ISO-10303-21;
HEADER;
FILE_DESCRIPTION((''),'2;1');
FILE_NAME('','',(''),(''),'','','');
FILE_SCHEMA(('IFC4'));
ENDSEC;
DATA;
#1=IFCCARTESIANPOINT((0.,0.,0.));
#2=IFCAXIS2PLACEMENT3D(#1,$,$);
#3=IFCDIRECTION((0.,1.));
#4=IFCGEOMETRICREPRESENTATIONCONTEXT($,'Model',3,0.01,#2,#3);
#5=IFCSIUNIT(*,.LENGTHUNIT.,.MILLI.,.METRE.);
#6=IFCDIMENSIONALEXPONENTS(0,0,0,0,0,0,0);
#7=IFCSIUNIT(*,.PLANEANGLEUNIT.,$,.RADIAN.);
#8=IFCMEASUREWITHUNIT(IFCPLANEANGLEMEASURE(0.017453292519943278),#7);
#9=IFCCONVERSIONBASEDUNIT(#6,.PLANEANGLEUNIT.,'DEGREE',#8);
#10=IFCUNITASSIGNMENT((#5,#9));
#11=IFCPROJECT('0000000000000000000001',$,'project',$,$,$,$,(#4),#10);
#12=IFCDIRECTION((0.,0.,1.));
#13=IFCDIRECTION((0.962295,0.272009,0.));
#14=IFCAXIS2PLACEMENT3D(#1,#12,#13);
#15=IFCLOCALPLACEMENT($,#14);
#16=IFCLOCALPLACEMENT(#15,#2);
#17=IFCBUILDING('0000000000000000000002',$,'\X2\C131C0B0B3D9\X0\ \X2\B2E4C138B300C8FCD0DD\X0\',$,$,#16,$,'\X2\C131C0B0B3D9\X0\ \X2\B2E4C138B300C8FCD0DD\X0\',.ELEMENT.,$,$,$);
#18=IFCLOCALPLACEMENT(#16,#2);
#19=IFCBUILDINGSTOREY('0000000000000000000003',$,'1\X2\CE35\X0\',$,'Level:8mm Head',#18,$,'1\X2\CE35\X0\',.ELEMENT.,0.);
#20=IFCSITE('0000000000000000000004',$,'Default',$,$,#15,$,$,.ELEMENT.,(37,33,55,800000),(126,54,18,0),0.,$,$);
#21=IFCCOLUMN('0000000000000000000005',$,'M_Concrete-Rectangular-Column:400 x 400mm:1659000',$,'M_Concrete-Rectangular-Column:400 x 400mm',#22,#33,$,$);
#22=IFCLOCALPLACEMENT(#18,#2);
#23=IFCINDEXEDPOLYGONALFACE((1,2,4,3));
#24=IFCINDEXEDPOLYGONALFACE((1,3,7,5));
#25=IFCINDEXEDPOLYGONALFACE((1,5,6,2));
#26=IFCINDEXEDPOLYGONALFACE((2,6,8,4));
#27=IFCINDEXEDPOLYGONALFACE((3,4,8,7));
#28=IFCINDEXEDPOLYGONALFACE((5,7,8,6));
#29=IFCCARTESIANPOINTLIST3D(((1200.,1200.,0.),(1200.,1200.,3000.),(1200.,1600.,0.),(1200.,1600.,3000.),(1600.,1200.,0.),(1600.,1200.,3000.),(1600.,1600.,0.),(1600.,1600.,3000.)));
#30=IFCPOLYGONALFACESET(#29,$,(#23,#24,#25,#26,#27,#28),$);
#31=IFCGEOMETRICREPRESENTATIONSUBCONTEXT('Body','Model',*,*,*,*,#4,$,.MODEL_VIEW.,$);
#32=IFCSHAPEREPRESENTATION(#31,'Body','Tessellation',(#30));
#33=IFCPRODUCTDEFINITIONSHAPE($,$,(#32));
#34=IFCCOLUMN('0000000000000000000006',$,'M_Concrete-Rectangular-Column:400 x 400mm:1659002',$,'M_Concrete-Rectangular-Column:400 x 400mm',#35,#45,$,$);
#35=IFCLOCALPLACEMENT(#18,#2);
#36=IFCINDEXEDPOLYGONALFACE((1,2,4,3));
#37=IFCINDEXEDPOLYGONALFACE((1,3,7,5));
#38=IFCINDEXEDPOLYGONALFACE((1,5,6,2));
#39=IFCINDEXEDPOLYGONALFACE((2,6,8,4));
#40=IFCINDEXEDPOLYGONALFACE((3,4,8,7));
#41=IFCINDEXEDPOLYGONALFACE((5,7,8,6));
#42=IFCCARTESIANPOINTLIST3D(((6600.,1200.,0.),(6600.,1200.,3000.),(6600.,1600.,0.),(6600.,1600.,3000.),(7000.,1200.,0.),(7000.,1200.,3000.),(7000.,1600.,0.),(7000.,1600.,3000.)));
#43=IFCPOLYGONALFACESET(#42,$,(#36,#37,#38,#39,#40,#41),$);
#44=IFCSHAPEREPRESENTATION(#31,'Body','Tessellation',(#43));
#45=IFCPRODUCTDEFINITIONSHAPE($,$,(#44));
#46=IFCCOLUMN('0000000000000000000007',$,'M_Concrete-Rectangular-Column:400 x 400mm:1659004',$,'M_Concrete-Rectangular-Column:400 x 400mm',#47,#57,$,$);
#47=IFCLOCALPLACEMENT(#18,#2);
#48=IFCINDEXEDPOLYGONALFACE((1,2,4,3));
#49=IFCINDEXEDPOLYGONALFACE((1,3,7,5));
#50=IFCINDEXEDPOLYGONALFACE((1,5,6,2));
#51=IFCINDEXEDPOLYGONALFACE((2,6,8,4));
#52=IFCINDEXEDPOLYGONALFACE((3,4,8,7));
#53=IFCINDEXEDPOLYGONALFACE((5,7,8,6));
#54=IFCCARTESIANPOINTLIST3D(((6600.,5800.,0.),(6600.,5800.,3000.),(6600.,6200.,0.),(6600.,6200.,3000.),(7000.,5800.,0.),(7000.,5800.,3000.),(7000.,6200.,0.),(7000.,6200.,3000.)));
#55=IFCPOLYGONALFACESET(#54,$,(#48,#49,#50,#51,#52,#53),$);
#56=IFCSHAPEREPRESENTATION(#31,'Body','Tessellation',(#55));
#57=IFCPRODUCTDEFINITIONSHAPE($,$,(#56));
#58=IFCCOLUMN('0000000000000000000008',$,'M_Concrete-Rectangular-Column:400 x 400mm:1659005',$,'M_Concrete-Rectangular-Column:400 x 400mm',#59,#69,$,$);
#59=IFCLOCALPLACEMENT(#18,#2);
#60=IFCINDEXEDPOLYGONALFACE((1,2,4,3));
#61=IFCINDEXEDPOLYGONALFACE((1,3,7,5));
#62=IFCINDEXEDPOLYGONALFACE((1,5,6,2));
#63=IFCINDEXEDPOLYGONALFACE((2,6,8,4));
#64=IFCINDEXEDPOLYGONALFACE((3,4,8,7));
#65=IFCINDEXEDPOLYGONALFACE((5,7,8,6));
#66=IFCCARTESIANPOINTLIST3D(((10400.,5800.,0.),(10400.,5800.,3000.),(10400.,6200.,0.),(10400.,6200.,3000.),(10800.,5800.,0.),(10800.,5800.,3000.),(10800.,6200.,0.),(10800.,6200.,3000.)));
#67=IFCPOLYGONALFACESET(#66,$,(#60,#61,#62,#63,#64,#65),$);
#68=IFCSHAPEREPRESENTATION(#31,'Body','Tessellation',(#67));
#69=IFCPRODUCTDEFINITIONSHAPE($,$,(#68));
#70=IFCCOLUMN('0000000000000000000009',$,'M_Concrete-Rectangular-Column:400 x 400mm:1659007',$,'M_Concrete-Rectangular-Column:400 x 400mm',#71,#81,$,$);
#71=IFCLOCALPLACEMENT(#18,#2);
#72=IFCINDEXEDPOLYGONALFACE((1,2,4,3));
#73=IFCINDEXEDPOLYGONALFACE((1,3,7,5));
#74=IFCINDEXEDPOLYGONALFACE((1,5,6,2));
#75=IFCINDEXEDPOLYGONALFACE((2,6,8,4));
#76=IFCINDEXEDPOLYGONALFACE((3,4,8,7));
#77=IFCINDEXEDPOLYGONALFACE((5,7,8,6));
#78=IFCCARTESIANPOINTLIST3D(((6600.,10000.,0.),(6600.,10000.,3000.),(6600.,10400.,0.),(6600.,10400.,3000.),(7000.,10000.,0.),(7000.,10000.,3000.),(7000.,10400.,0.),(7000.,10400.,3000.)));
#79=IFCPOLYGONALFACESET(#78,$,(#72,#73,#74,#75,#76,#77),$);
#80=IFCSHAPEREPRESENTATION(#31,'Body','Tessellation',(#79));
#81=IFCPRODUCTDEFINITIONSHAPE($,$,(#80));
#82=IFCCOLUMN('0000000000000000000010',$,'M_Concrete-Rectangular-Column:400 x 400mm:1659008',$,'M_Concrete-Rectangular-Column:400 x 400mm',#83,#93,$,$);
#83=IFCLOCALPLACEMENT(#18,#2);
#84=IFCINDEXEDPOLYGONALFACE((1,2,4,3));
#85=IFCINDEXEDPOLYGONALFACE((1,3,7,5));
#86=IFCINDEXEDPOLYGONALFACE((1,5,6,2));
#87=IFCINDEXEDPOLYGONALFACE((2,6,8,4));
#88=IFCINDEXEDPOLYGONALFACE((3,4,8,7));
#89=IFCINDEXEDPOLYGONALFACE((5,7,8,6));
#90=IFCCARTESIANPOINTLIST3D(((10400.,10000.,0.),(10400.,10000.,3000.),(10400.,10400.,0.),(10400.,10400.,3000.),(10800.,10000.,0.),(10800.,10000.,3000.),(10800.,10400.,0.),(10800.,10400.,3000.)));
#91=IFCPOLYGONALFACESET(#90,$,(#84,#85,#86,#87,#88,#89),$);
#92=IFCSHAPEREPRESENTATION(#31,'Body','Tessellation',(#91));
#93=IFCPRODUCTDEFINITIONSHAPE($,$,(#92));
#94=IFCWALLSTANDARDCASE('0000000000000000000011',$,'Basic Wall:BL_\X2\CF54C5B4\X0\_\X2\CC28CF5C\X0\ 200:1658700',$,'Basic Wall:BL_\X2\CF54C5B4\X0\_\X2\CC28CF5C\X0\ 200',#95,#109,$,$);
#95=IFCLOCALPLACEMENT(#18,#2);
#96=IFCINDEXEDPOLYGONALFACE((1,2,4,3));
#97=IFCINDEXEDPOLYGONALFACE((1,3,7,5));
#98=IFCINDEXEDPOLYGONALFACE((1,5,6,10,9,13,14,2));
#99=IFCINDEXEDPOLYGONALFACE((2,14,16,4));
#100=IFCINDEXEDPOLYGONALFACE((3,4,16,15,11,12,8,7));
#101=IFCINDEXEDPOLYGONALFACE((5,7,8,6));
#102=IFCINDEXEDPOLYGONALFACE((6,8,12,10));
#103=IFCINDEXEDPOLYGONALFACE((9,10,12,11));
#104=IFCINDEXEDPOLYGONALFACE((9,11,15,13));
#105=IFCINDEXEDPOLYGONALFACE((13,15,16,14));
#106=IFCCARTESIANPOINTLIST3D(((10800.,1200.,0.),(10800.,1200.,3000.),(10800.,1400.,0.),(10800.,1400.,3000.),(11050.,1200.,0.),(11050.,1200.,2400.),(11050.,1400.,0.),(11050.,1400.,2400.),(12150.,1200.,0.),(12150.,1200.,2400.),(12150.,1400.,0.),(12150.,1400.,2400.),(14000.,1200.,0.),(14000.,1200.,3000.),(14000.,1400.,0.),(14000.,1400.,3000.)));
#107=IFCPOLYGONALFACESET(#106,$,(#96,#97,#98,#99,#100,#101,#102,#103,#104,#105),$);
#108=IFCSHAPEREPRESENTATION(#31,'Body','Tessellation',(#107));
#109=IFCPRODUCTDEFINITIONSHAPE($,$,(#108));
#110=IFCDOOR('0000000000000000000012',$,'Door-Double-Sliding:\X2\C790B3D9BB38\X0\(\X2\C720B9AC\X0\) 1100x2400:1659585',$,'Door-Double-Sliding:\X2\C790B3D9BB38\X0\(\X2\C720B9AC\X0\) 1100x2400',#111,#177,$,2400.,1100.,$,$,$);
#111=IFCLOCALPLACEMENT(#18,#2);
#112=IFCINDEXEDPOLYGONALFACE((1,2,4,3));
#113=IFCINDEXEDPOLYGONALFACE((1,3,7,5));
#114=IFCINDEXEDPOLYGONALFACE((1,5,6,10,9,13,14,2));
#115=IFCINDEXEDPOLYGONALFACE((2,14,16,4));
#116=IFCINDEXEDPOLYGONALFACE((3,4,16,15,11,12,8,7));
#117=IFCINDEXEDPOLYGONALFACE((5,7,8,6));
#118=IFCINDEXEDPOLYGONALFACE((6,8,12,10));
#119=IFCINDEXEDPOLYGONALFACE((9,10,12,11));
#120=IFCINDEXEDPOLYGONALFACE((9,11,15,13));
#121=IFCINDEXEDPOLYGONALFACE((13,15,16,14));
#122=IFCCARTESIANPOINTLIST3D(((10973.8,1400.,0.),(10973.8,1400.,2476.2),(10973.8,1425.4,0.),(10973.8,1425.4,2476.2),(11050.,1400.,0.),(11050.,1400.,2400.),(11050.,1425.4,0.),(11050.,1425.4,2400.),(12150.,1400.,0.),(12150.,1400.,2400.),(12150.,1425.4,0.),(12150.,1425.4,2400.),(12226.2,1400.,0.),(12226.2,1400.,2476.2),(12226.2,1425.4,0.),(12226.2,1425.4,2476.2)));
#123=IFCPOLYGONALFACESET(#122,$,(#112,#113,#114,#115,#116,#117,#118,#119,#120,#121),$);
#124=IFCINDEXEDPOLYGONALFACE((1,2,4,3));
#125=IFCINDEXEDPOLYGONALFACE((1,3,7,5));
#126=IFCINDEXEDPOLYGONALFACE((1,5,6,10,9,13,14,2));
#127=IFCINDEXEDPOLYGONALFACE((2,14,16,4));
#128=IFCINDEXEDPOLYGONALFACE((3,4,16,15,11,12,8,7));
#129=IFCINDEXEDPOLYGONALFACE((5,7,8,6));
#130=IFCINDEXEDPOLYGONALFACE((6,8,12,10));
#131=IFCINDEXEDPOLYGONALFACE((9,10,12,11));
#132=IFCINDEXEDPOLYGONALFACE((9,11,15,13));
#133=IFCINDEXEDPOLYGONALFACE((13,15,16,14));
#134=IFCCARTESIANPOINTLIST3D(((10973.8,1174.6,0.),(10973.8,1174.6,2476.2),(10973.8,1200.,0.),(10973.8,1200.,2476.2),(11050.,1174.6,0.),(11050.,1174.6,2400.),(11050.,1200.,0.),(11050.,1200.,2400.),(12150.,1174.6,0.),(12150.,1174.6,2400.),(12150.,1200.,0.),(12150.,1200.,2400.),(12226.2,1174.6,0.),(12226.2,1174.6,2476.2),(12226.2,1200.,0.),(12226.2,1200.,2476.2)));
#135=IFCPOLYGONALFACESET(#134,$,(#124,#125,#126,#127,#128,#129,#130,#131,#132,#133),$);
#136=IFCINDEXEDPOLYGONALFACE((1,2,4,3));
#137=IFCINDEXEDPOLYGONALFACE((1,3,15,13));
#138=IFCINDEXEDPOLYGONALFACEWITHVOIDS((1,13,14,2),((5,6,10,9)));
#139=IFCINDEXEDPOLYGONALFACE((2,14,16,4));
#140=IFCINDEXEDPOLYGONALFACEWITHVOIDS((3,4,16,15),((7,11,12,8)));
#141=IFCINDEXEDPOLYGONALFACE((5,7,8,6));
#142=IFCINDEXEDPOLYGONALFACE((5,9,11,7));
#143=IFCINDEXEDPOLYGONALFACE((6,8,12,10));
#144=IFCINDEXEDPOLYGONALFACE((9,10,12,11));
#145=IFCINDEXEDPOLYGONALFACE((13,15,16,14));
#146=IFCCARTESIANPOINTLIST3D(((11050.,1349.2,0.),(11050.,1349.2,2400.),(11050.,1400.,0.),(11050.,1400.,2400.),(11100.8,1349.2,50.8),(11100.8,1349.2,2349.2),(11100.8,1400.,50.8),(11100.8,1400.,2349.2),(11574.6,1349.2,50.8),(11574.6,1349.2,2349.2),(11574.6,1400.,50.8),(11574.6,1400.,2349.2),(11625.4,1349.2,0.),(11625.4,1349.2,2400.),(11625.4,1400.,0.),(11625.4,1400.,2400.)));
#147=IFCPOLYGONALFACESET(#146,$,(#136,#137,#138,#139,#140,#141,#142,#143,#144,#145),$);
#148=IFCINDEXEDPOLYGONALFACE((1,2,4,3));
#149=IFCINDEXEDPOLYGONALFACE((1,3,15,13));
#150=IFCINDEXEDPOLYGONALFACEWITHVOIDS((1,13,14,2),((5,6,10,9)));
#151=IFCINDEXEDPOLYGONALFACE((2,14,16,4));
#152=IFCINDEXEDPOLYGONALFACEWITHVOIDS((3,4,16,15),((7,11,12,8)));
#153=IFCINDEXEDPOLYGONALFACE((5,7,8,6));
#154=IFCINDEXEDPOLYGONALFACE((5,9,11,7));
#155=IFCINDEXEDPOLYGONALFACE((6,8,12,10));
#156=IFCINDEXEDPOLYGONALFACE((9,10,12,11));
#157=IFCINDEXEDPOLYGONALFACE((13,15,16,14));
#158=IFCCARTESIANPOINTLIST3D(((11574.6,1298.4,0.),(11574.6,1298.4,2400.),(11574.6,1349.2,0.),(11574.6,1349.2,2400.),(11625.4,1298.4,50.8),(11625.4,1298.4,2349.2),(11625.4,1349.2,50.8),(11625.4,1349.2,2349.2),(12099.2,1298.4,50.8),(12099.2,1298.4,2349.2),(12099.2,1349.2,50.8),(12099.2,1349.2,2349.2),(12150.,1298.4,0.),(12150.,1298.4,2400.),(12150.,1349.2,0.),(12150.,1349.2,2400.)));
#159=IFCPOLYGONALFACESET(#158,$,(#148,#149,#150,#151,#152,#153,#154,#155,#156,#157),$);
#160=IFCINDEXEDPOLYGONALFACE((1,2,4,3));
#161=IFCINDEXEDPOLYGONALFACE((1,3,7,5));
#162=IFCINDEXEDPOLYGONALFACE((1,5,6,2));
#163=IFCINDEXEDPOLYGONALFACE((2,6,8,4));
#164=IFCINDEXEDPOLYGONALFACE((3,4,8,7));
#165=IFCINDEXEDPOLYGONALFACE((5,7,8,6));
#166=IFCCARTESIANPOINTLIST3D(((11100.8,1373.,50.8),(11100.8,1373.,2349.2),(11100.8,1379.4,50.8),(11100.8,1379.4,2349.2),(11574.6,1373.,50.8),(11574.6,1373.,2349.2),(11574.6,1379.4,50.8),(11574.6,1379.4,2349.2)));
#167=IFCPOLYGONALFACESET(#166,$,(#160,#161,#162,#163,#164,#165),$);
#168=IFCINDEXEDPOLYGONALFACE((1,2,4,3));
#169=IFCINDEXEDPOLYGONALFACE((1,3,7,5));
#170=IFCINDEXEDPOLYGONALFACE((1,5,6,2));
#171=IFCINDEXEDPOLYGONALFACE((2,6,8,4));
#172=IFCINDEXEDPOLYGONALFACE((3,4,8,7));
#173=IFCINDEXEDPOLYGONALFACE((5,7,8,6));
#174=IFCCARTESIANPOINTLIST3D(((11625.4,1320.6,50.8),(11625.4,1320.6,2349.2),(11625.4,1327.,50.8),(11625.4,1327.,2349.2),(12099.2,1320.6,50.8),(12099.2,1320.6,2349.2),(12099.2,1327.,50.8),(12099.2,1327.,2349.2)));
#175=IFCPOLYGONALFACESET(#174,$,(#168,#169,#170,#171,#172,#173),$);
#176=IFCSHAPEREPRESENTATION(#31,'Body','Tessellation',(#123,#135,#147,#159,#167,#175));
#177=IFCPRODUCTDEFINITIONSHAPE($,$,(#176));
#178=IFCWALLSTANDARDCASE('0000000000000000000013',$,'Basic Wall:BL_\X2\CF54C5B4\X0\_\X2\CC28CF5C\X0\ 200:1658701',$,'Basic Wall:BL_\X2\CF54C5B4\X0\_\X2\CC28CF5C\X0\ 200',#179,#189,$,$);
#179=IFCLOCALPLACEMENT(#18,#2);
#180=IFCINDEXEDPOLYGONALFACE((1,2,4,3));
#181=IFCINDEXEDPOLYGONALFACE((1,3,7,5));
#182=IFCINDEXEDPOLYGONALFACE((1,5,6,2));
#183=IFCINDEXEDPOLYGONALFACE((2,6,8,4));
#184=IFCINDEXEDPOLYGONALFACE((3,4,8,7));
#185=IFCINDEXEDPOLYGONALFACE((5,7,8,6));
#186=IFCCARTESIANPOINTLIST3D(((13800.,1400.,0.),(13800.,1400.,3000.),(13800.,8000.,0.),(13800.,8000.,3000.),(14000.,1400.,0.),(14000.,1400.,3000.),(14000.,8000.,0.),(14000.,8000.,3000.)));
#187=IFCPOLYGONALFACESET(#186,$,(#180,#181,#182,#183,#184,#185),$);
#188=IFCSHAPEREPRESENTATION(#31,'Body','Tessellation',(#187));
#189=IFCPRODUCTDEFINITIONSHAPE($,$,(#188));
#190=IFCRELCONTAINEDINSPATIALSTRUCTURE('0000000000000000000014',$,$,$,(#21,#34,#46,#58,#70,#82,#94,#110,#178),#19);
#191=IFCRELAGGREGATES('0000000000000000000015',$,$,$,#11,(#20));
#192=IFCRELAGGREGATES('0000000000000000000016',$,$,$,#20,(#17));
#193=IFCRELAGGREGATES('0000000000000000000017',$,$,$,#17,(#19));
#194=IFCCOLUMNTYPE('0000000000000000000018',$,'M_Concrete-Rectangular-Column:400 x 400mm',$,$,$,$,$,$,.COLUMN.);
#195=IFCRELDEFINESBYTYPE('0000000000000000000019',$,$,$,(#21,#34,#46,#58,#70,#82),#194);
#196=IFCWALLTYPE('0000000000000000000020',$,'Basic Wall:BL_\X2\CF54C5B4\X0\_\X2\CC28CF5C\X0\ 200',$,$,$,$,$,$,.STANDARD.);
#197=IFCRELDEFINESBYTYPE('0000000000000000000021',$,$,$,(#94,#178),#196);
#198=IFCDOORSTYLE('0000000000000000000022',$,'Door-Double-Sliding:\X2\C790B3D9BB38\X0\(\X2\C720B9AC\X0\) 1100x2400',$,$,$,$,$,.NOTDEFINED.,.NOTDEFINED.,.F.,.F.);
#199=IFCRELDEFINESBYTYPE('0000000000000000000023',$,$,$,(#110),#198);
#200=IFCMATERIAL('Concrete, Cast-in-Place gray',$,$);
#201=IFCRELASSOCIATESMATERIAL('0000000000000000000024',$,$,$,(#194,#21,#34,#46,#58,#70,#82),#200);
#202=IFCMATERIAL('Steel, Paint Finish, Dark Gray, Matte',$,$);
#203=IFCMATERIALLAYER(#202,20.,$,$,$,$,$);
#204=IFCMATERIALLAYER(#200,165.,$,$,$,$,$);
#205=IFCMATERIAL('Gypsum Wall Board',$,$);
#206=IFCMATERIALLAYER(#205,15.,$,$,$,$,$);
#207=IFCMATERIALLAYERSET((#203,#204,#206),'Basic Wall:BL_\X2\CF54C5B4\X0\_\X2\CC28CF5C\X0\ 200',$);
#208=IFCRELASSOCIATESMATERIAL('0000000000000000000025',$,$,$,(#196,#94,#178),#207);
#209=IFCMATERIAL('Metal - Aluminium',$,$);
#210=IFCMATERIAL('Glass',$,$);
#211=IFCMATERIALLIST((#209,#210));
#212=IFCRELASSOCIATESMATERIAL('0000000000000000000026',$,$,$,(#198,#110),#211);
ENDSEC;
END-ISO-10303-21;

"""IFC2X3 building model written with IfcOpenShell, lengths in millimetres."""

from ifc_helpers import new_model, entity, si_unit, converted_unit, direction, frame, frame_2d, origin, origin_2d_with_axis, place, context, subcontext, project, spatial, polyline, rectangle, outline, extrude, source, transform, mapped, material, material_list, layer, layer_set, layer_usage, type_object, type_shapes, element, fill, save


model = new_model("IFC2X3")

# Units and contexts
model_context = context("Model", 3, precision=0.01, world=origin(), true_north=direction((0.0, 1.0)))
body_context = subcontext(model_context, "Body", "Model", "MODEL_VIEW")
ifc_project = project(units=[si_unit("LENGTHUNIT", "METRE", prefix="MILLI"), converted_unit("PLANEANGLEUNIT", "DEGREE", entity("IfcPlaneAngleMeasure", 0.017453292519943278), si_unit("PLANEANGLEUNIT", "RADIAN"), dimensions=[0, 0, 0, 0, 0, 0, 0])], contexts=[model_context])

# Site, building, storey
site_placement = place(None, frame((0.0, 0.0, 0.0), z_axis=(0.0, 0.0, 1.0), x_axis=(0.962295, 0.272009, 0.0)))
site = spatial("IfcSite", under=ifc_project, at=site_placement, Name="Default", CompositionType="ELEMENT", RefLatitude=(37, 33, 55, 800000), RefLongitude=(126, 54, 18, 0), RefElevation=0.0)
building_placement = place(site_placement, origin())
building = spatial("IfcBuilding", under=site, at=building_placement, Name="성산동 다세대주택", LongName="성산동 다세대주택", CompositionType="ELEMENT")
storey_placement = place(building_placement, origin())
storey = spatial("IfcBuildingStorey", under=building, at=storey_placement, Name="1층", ObjectType="Level:8mm Head", LongName="1층", CompositionType="ELEMENT", Elevation=0.0)

# Columns
ifc_material_1 = material(Name="Concrete, Cast-in-Place gray")
column_type = type_object("IfcColumnType", Name="M_Concrete-Rectangular-Column:400 x 400mm", PredefinedType="COLUMN", material=ifc_material_1)
shared_shape_1 = source(origin(), body_context, "Body", "SweptSolid", [
    extrude(rectangle(XDim=400.0, YDim=400.0, at=origin_2d_with_axis()), frame((0.0, 0.0, 0.0), z_axis=(0.0, 0.0, 1.0), x_axis=(-1.0, 0.0, 0.0)), (0.0, 0.0, 1.0), 3000.0),
])
type_shapes(column_type, [shared_shape_1])
for number, where, name in (
    (1, (1400.0, 1400.0, 0.0), "M_Concrete-Rectangular-Column:400 x 400mm:1659000"),
    (2, (6800.0, 1400.0, 0.0), "M_Concrete-Rectangular-Column:400 x 400mm:1659002"),
    (3, (6800.0, 6000.0, 0.0), "M_Concrete-Rectangular-Column:400 x 400mm:1659004"),
    (4, (10600.0, 6000.0, 0.0), "M_Concrete-Rectangular-Column:400 x 400mm:1659005"),
    (5, (6800.0, 10200.0, 0.0), "M_Concrete-Rectangular-Column:400 x 400mm:1659007"),
    (6, (10600.0, 10200.0, 0.0), "M_Concrete-Rectangular-Column:400 x 400mm:1659008"),
):
    element("IfcColumn", number, at=place(storey_placement, frame(where)), inside=storey, type_object=column_type, material=ifc_material_1, Name=name, ObjectType="M_Concrete-Rectangular-Column:400 x 400mm", context=body_context, shape_type="MappedRepresentation", body=[
        mapped(shared_shape_1, transform((0.0, 0.0, 0.0), scale=1.0)),
    ])

# Wall, opening, door
ifc_material_2 = material(Name="Steel, Paint Finish, Dark Gray, Matte")
ifc_layer_1 = layer(ifc_material_2, 20.0)
ifc_layer_2 = layer(ifc_material_1, 165.0)
ifc_material_3 = material(Name="Gypsum Wall Board")
ifc_layer_3 = layer(ifc_material_3, 15.0)
ifc_layer_set_1 = layer_set([ifc_layer_1, ifc_layer_2, ifc_layer_3], Name="Basic Wall:BL_코어_차콜 200")
ifc_layer_usage_1 = layer_usage(ifc_layer_set_1, "AXIS2", "POSITIVE", -100.0)
wall_type_1 = type_object("IfcWallType", Name="Basic Wall:BL_코어_차콜 200", PredefinedType="STANDARD", material=ifc_layer_set_1)
wall_1_placement = place(storey_placement, frame((10800.0, 1300.0, 0.0)))
wall_1 = element("IfcWallStandardCase", 7, at=wall_1_placement, inside=storey, type_object=wall_type_1, material=ifc_layer_usage_1, Name="Basic Wall:BL_코어_차콜 200:1658700", ObjectType="Basic Wall:BL_코어_차콜 200", context=body_context, shape_type="SweptSolid", body=[
    extrude(rectangle(XDim=3200.0, YDim=200.0, at=frame_2d((1600.0, 0.0), x_axis=(1.0, 0.0))), origin(), (0.0, 0.0, 1.0), 3000.0),
])
opening_1_placement = place(wall_1_placement, frame((250.0, -100.0, 0.0)))
opening_1 = element("IfcOpeningElement", 8, at=opening_1_placement, cuts=wall_1, ObjectType="Opening", context=body_context, shape_type="SweptSolid", body=[
    extrude(rectangle(XDim=2400.0, YDim=1100.0, at=frame_2d((1200.0, 550.0), x_axis=(-1.0, 0.0))), frame((0.0, 0.0, 0.0), z_axis=(0.0, 1.0, 0.0), x_axis=(0.0, 0.0, 1.0)), (0.0, 0.0, 1.0), 200.0),
])
ifc_material_4 = material(Name="Metal - Aluminium")
ifc_material_5 = material(Name="Glass")
ifc_material_list_1 = material_list([ifc_material_4, ifc_material_5])
door_style_1 = type_object("IfcDoorStyle", Name="Door-Double-Sliding:자동문(유리) 1100x2400", ConstructionType="NOTDEFINED", OperationType="NOTDEFINED", ParameterTakesPrecedence=False, Sizeable=False, material=ifc_material_list_1)
shared_shape_2 = source(origin(), body_context, "Body", "SweptSolid", [
    extrude(outline(polyline([(-626.2, -1219.1), (-550.0, -1219.1), (-550.0, 1180.9), (550.0, 1181.0), (550.0, -1219.0), (626.2, -1219.0), (626.2, 1257.1), (-626.2, 1257.1), (-626.2, -1219.1)])), frame((550.0, 200.0, 1219.0), z_axis=(0.0, 1.0, 0.0), x_axis=(-1.0, 0.0, 0.0)), (0.0, 0.0, 1.0), 25.4),
    extrude(outline(polyline([(-1219.0, -626.2), (1257.1, -626.2), (1257.1, 626.2), (-1219.0, 626.2), (-1219.0, 550.0), (1180.9, 550.0), (1180.9, -550.0), (-1219.0, -550.0), (-1219.0, -626.2)])), frame((550.0, -25.4, 1219.0), z_axis=(0.0, 1.0, 0.0), x_axis=(0.0, 0.0, 1.0)), (0.0, 0.0, 1.0), 25.4),
    extrude(outline(polyline([(-1200.0, -287.7), (1200.0, -287.7), (1200.0, 287.7), (-1200.0, 287.7), (-1200.0, -287.7)]), holes=[polyline([(-1149.2, -236.9), (-1149.2, 236.9), (1149.2, 236.9), (1149.2, -236.9), (-1149.2, -236.9)])]), frame((287.7, 149.2, 1200.0), z_axis=(0.0, 1.0, 0.0), x_axis=(0.0, 0.0, -1.0)), (0.0, 0.0, 1.0), 50.8),
    extrude(outline(polyline([(-287.7, -1200.0), (287.7, -1200.0), (287.7, 1200.0), (-287.7, 1200.0), (-287.7, -1200.0)]), holes=[polyline([(-236.9, -1149.2), (-236.9, 1149.2), (236.9, 1149.2), (236.9, -1149.2), (-236.9, -1149.2)])]), frame((812.3, 98.4, 1200.0), z_axis=(0.0, 1.0, 0.0), x_axis=(1.0, 0.0, 0.0)), (0.0, 0.0, 1.0), 50.8),
    extrude(rectangle(XDim=6.4, YDim=473.8, at=frame_2d((0.0, 0.0), x_axis=(1.0, 0.0))), frame((287.7, 176.2, 50.8), z_axis=(0.0, 0.0, 1.0), x_axis=(0.0, 1.0, 0.0)), (0.0, 0.0, 1.0), 2298.4),
    extrude(rectangle(XDim=6.3, YDim=473.8, at=origin_2d_with_axis()), frame((812.3, 123.8, 50.8), z_axis=(0.0, 0.0, 1.0), x_axis=(0.0, -1.0, 0.0)), (0.0, 0.0, 1.0), 2298.4),
])
type_shapes(door_style_1, [shared_shape_2])
door_1_placement = place(opening_1_placement, origin())
door_1 = element("IfcDoor", 9, at=door_1_placement, inside=storey, type_object=door_style_1, material=ifc_material_list_1, Name="Door-Double-Sliding:자동문(유리) 1100x2400:1659585", ObjectType="Door-Double-Sliding:자동문(유리) 1100x2400", OverallHeight=2400.0, OverallWidth=1100.0, context=body_context, shape_type="MappedRepresentation", body=[
    mapped(shared_shape_2, transform((0.0, 0.0, 0.0), scale=1.0)),
])
fill(opening_1, door_1)

# Wall
ifc_layer_usage_2 = layer_usage(ifc_layer_set_1, "AXIS2", "POSITIVE", -100.0)
wall_2_placement = place(storey_placement, frame((13900.0, 1400.0, 0.0), z_axis=(0.0, 0.0, 1.0), x_axis=(0.0, 1.0, 0.0)))
element("IfcWallStandardCase", 10, at=wall_2_placement, inside=storey, type_object=wall_type_1, material=ifc_layer_usage_2, Name="Basic Wall:BL_코어_차콜 200:1658701", ObjectType="Basic Wall:BL_코어_차콜 200", context=body_context, shape_type="SweptSolid", body=[
    extrude(rectangle(XDim=6600.0, YDim=200.0, at=frame_2d((3300.0, 0.0), x_axis=(-1.0, 0.0))), origin(), (0.0, 0.0, 1.0), 3000.0),
])

save(model, "model.ifc")
